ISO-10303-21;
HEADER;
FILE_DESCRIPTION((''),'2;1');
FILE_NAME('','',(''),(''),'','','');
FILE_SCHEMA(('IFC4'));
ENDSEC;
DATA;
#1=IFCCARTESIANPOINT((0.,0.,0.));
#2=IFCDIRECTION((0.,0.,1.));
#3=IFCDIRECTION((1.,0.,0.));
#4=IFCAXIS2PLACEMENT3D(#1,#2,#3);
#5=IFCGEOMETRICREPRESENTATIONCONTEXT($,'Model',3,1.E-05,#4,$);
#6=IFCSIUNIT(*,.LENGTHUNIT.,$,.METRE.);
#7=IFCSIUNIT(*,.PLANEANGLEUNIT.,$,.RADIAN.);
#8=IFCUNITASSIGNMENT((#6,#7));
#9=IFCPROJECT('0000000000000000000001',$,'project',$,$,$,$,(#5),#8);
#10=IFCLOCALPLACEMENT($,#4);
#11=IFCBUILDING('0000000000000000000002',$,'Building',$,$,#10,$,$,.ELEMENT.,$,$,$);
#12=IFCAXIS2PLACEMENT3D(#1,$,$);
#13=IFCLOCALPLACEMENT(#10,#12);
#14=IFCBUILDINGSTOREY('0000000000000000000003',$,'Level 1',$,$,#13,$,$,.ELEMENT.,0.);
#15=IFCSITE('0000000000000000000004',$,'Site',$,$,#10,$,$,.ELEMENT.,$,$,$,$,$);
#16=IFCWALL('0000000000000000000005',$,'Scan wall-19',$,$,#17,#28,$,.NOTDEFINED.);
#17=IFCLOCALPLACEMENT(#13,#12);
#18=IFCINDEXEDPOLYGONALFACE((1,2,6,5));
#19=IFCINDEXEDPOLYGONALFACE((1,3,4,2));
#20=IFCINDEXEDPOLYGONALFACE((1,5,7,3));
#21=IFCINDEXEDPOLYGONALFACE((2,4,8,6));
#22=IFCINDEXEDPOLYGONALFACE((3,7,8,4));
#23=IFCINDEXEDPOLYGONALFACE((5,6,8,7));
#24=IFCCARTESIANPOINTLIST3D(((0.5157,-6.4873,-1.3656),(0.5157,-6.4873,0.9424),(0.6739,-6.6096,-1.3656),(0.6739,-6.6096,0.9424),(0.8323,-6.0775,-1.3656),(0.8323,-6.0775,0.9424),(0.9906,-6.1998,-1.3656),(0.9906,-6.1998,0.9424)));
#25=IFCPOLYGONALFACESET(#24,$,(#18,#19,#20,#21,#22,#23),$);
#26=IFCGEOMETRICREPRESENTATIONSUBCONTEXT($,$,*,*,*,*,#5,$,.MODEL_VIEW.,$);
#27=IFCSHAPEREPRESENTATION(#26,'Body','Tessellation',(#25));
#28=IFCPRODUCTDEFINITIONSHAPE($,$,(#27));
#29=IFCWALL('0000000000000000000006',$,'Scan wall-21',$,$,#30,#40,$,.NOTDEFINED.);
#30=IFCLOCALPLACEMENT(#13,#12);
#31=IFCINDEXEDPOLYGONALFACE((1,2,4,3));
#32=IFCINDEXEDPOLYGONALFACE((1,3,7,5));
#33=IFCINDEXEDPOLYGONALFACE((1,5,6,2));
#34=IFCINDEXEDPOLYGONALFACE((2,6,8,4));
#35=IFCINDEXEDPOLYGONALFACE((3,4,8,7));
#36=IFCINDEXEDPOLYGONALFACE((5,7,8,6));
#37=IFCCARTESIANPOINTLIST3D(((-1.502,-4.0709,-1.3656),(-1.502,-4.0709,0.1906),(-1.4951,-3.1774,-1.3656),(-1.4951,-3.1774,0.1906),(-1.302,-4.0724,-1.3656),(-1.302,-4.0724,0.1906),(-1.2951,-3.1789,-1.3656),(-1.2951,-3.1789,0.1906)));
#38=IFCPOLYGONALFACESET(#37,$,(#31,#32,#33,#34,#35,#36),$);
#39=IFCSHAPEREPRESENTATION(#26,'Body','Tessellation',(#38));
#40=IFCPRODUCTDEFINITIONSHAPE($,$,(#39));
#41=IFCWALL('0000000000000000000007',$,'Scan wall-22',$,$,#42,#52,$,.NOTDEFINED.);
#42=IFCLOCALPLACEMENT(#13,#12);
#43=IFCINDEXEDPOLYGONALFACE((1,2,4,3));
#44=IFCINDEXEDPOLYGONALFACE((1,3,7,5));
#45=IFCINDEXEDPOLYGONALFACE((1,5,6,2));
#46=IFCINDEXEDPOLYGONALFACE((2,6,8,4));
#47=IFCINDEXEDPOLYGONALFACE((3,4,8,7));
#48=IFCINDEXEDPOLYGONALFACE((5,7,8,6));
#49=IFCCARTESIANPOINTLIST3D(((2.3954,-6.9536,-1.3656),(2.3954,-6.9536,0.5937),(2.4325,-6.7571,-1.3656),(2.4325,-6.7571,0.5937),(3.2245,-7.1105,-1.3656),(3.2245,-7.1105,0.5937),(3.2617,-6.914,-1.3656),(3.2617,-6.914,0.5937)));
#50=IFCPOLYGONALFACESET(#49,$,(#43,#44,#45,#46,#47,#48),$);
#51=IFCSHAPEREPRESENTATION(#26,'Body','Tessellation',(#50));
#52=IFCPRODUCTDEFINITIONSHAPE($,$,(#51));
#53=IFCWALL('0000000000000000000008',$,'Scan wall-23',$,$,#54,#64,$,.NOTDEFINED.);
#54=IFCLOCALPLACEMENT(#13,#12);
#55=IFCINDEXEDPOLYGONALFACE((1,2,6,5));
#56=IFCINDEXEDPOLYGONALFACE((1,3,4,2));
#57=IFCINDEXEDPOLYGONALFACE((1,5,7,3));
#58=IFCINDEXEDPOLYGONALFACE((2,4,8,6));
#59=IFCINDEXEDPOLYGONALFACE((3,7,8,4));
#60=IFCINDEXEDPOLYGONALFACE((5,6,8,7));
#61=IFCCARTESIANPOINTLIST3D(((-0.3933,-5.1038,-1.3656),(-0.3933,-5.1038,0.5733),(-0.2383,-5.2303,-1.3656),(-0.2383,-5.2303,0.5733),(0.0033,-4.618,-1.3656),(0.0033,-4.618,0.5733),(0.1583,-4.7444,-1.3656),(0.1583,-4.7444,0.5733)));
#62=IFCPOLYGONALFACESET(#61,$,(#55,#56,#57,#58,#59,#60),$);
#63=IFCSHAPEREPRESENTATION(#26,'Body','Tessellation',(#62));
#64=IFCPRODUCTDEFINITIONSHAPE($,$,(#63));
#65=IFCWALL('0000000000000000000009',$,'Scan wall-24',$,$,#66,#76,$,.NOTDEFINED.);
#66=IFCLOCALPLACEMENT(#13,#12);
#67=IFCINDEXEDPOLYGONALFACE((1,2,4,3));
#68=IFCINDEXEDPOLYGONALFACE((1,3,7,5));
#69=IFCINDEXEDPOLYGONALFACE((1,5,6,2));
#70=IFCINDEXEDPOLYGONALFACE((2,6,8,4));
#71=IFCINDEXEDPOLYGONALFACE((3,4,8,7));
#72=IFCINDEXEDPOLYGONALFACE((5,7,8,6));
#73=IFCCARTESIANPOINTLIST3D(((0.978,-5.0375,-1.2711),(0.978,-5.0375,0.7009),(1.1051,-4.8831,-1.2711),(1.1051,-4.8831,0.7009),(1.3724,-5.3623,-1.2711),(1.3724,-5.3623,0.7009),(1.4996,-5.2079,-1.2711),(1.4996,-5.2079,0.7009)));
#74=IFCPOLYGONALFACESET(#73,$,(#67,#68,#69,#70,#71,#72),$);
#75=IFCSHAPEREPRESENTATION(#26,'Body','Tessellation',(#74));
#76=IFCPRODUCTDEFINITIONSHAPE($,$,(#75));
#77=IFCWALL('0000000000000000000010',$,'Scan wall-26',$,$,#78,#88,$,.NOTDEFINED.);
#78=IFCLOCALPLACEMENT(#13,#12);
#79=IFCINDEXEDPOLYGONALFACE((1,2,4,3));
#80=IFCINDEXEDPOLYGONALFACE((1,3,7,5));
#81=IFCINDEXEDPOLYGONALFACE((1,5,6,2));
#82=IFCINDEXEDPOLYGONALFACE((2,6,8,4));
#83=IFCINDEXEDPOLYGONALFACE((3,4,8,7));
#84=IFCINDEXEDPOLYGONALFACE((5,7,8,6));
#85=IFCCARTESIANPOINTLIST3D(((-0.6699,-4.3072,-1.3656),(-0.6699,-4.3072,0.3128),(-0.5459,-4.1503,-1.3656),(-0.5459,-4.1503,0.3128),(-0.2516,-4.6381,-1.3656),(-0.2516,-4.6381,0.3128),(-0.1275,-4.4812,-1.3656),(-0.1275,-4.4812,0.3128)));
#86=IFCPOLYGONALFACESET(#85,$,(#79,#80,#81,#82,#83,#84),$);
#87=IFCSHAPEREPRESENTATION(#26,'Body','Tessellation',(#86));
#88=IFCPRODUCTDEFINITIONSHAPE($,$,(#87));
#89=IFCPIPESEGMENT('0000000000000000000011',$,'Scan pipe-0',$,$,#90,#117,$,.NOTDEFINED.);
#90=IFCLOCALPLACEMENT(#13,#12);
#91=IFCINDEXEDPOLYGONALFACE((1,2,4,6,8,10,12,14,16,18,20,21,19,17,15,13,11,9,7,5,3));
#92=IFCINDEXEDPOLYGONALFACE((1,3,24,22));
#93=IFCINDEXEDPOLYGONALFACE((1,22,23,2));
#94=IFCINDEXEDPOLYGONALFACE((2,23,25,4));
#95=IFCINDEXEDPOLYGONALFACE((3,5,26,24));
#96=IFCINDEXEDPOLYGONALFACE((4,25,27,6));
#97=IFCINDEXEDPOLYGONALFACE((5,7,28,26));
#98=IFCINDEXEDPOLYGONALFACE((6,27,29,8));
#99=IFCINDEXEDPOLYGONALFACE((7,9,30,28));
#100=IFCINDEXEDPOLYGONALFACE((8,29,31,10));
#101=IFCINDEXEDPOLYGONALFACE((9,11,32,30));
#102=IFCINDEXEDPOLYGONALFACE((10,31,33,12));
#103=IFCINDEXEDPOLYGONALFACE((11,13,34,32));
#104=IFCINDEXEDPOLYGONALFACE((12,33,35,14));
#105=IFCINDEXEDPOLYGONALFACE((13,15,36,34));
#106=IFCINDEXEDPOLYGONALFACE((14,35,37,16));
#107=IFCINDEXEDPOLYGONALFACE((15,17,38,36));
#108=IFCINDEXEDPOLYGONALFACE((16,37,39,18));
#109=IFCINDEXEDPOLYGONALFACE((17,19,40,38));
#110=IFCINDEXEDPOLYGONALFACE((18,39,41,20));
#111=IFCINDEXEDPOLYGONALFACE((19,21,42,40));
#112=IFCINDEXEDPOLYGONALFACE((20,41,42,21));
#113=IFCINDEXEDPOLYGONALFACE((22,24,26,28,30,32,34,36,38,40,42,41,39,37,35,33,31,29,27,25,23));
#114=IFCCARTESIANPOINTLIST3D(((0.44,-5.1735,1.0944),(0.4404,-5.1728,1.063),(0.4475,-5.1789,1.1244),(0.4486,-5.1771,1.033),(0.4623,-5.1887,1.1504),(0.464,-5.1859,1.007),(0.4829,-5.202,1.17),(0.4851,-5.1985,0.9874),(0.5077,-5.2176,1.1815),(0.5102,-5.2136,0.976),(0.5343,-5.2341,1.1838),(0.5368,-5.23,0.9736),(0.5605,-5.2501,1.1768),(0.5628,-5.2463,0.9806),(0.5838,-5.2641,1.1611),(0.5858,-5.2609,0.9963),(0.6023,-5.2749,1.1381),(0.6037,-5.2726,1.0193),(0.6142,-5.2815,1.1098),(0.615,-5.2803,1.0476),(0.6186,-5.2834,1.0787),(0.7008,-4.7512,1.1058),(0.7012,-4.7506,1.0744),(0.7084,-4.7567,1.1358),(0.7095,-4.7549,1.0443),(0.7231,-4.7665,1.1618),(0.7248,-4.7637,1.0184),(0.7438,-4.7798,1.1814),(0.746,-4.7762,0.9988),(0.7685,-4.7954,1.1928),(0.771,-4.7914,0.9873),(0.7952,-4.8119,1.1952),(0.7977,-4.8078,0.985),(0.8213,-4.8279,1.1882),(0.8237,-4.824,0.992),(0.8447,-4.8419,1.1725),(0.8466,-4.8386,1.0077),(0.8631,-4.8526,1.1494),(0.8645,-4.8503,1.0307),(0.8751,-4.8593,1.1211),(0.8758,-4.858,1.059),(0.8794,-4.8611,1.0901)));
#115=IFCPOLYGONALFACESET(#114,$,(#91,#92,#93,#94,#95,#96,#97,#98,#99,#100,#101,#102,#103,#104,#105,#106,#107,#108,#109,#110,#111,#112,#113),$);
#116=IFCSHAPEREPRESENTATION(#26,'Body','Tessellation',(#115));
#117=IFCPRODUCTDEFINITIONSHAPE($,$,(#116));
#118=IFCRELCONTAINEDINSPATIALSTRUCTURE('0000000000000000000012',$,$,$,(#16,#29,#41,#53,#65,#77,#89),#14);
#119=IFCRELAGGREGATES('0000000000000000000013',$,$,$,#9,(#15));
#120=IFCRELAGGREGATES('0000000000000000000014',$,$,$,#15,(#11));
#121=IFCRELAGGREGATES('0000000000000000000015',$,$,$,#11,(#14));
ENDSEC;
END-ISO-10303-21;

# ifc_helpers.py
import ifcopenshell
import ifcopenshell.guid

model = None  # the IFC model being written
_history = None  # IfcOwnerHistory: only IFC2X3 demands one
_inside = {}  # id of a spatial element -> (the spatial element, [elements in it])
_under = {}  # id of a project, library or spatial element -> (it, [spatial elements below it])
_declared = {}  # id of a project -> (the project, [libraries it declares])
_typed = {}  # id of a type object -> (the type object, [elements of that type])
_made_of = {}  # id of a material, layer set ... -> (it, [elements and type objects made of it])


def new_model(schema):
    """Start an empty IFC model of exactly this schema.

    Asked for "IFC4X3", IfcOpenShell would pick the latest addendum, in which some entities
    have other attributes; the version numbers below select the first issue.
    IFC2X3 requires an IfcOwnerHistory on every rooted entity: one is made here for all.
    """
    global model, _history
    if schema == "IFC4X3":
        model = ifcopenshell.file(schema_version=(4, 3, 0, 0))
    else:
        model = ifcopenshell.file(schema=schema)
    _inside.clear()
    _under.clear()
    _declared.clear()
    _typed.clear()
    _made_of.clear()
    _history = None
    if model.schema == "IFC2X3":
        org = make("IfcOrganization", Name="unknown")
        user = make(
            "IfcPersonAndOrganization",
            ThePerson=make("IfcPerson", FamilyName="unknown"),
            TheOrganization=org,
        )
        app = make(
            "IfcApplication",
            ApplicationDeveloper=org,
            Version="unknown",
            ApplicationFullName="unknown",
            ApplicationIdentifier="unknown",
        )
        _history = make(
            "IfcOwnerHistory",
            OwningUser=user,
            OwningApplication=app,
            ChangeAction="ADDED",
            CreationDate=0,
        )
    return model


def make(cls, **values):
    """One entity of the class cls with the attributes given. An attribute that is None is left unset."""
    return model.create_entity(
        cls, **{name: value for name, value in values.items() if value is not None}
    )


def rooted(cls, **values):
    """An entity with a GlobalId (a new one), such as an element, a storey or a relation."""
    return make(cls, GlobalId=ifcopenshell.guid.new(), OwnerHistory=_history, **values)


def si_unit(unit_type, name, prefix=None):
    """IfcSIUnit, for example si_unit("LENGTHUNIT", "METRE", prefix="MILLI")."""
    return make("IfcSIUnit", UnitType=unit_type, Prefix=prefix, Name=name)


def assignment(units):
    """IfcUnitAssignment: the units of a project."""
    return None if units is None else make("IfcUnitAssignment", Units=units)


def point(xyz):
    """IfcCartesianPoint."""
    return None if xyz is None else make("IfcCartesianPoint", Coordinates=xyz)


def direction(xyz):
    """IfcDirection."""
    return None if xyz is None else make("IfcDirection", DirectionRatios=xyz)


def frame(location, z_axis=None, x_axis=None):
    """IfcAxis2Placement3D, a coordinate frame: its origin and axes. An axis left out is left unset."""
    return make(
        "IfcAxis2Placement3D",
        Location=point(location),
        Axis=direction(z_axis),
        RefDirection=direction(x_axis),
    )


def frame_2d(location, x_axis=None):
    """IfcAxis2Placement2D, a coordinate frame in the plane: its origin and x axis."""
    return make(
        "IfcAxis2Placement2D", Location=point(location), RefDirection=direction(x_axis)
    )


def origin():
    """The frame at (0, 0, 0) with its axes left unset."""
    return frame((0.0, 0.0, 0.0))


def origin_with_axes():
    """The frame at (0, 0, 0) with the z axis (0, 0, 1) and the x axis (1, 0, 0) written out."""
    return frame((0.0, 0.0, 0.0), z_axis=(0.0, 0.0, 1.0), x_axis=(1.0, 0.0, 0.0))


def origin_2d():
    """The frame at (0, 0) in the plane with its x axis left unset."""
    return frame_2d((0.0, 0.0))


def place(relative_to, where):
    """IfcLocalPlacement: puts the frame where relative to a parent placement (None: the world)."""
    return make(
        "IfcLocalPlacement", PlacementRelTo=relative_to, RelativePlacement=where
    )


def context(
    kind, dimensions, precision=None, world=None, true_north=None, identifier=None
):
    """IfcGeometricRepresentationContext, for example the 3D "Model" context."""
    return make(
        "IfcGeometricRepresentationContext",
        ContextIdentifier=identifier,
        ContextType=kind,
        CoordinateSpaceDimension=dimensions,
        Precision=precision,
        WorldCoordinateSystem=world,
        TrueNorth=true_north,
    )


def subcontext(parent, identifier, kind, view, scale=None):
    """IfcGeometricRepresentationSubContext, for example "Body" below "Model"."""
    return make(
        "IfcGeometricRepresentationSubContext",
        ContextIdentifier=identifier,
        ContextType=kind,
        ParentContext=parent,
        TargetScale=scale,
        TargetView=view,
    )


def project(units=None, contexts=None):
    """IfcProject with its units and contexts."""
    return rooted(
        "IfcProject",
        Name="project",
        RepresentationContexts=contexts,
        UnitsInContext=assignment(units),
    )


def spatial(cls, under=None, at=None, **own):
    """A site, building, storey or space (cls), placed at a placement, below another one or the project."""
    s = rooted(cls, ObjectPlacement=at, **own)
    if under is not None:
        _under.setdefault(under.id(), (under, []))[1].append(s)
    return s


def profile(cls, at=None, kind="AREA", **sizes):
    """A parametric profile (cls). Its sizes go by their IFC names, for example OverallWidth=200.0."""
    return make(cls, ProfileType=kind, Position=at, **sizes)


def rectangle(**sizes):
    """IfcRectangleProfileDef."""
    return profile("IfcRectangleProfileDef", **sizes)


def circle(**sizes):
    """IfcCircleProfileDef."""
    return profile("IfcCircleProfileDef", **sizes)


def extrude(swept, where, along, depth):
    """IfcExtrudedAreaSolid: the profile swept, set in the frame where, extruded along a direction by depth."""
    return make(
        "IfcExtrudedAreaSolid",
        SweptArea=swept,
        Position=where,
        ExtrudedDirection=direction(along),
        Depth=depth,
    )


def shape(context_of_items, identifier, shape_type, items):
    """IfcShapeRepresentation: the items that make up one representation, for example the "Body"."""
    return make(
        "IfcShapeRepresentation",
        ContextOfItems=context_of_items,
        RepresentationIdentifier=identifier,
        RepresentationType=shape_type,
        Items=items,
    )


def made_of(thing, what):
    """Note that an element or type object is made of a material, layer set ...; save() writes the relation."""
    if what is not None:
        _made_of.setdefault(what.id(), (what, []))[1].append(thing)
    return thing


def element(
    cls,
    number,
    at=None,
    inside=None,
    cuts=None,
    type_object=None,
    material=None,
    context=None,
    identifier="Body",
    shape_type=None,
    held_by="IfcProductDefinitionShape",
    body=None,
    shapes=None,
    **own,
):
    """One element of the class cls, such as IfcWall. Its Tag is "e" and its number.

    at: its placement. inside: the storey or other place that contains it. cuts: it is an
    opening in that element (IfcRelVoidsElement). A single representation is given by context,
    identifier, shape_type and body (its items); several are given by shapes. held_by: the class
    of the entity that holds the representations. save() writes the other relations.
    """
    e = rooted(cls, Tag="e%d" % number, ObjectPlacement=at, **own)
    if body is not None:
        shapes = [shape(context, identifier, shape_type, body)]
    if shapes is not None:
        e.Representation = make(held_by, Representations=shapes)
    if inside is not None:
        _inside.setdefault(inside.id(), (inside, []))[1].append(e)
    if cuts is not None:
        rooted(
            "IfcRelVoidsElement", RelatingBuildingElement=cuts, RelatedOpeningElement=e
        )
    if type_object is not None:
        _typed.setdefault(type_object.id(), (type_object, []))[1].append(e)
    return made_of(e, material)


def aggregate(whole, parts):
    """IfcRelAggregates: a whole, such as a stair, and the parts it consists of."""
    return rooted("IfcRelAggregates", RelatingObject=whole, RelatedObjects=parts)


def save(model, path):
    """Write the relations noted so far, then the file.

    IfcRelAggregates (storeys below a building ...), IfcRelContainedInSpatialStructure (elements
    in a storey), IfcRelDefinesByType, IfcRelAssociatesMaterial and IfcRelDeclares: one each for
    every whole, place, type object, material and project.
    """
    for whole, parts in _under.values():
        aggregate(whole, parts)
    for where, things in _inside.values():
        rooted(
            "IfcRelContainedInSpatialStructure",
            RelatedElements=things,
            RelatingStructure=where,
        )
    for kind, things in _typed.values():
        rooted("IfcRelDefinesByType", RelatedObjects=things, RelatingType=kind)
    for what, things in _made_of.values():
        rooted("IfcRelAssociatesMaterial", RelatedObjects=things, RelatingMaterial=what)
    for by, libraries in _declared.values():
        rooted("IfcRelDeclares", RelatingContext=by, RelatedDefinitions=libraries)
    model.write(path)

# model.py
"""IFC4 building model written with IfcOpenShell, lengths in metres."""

from ifc_helpers import new_model, si_unit, frame, frame_2d, origin, origin_with_axes, origin_2d, place, context, subcontext, project, spatial, rectangle, circle, extrude, element, save


model = new_model("IFC4")

# Units and contexts
model_context = context("Model", 3, precision=1e-05, world=origin_with_axes())
sub_context = subcontext(model_context, None, None, "MODEL_VIEW")
ifc_project = project(units=[si_unit("LENGTHUNIT", "METRE"), si_unit("PLANEANGLEUNIT", "RADIAN")], contexts=[model_context])

# Site, building, storey
placement = place(None, origin_with_axes())
site = spatial("IfcSite", under=ifc_project, at=placement, Name="Site", CompositionType="ELEMENT")
building = spatial("IfcBuilding", under=site, at=placement, Name="Building", CompositionType="ELEMENT")
storey_placement = place(placement, origin())
storey = spatial("IfcBuildingStorey", under=building, at=storey_placement, Name="Level 1", CompositionType="ELEMENT", Elevation=0.0)

# Walls
wall_1_placement = place(storey_placement, frame((0.5948, -6.5485, -1.3656), z_axis=(0.0, 0.0, 1.0), x_axis=(0.611399, 0.791323, 0.0)))
element("IfcWall", 1, at=wall_1_placement, inside=storey, Name="Scan wall-19", PredefinedType="NOTDEFINED", context=sub_context, shape_type="SweptSolid", body=[
    extrude(rectangle(XDim=0.5179, YDim=0.2, at=frame_2d((0.2589, 0.0))), origin(), (0.0, 0.0, 1.0), 2.3079),
])
wall_2_placement = place(storey_placement, frame((-1.402, -4.0716, -1.3656), z_axis=(0.0, 0.0, 1.0), x_axis=(0.007648, 0.999971, 0.0)))
element("IfcWall", 2, at=wall_2_placement, inside=storey, Name="Scan wall-21", PredefinedType="NOTDEFINED", context=sub_context, shape_type="SweptSolid", body=[
    extrude(rectangle(XDim=0.8935, YDim=0.2, at=frame_2d((0.4467, 0.0))), origin(), (0.0, 0.0, 1.0), 1.5562),
])
wall_3_placement = place(storey_placement, frame((3.2431, -7.0123, -1.3656), z_axis=(0.0, 0.0, 1.0), x_axis=(-0.982558, 0.185957, 0.0)))
element("IfcWall", 3, at=wall_3_placement, inside=storey, Name="Scan wall-22", PredefinedType="NOTDEFINED", context=sub_context, shape_type="SweptSolid", body=[
    extrude(rectangle(XDim=0.8439, YDim=0.2, at=frame_2d((0.4219, 0.0))), origin(), (0.0, 0.0, 1.0), 1.9593),
])
wall_4_placement = place(storey_placement, frame((-0.3158, -5.1671, -1.3656), z_axis=(0.0, 0.0, 1.0), x_axis=(0.632341, 0.774691, 0.0)))
element("IfcWall", 4, at=wall_4_placement, inside=storey, Name="Scan wall-23", PredefinedType="NOTDEFINED", context=sub_context, shape_type="SweptSolid", body=[
    extrude(rectangle(XDim=0.6272, YDim=0.2, at=frame_2d((0.3136, 0.0))), origin(), (0.0, 0.0, 1.0), 1.9389),
])
wall_5_placement = place(storey_placement, frame((1.436, -5.2851, -1.2711), z_axis=(0.0, 0.0, 1.0), x_axis=(-0.771995, 0.635629, 0.0)))
element("IfcWall", 5, at=wall_5_placement, inside=storey, Name="Scan wall-24", PredefinedType="NOTDEFINED", context=sub_context, shape_type="SweptSolid", body=[
    extrude(rectangle(XDim=0.511, YDim=0.2, at=frame_2d((0.2555, 0.0))), origin(), (0.0, 0.0, 1.0), 1.972),
])
wall_6_placement = place(storey_placement, frame((-0.1895, -4.5596, -1.3656), z_axis=(0.0, 0.0, 1.0), x_axis=(-0.784372, 0.62029, 0.0)))
element("IfcWall", 6, at=wall_6_placement, inside=storey, Name="Scan wall-26", PredefinedType="NOTDEFINED", context=sub_context, shape_type="SweptSolid", body=[
    extrude(rectangle(XDim=0.5334, YDim=0.2, at=frame_2d((0.2667, 0.0))), origin(), (0.0, 0.0, 1.0), 1.6784),
])

# Pipe segment
pipe_segment_placement = place(storey_placement, frame((0.7897, -4.8057, 1.0901), z_axis=(-0.52543, -0.850529, -0.022886), x_axis=(0.850752, -0.525568, 0.0)))
element("IfcPipeSegment", 7, at=pipe_segment_placement, inside=storey, Name="Scan pipe-0", PredefinedType="NOTDEFINED", context=sub_context, shape_type="SweptSolid", body=[
    extrude(circle(Radius=0.1054, at=origin_2d()), origin(), (0.0, 0.0, 1.0), 0.4965),
])

save(model, "model.ifc")
